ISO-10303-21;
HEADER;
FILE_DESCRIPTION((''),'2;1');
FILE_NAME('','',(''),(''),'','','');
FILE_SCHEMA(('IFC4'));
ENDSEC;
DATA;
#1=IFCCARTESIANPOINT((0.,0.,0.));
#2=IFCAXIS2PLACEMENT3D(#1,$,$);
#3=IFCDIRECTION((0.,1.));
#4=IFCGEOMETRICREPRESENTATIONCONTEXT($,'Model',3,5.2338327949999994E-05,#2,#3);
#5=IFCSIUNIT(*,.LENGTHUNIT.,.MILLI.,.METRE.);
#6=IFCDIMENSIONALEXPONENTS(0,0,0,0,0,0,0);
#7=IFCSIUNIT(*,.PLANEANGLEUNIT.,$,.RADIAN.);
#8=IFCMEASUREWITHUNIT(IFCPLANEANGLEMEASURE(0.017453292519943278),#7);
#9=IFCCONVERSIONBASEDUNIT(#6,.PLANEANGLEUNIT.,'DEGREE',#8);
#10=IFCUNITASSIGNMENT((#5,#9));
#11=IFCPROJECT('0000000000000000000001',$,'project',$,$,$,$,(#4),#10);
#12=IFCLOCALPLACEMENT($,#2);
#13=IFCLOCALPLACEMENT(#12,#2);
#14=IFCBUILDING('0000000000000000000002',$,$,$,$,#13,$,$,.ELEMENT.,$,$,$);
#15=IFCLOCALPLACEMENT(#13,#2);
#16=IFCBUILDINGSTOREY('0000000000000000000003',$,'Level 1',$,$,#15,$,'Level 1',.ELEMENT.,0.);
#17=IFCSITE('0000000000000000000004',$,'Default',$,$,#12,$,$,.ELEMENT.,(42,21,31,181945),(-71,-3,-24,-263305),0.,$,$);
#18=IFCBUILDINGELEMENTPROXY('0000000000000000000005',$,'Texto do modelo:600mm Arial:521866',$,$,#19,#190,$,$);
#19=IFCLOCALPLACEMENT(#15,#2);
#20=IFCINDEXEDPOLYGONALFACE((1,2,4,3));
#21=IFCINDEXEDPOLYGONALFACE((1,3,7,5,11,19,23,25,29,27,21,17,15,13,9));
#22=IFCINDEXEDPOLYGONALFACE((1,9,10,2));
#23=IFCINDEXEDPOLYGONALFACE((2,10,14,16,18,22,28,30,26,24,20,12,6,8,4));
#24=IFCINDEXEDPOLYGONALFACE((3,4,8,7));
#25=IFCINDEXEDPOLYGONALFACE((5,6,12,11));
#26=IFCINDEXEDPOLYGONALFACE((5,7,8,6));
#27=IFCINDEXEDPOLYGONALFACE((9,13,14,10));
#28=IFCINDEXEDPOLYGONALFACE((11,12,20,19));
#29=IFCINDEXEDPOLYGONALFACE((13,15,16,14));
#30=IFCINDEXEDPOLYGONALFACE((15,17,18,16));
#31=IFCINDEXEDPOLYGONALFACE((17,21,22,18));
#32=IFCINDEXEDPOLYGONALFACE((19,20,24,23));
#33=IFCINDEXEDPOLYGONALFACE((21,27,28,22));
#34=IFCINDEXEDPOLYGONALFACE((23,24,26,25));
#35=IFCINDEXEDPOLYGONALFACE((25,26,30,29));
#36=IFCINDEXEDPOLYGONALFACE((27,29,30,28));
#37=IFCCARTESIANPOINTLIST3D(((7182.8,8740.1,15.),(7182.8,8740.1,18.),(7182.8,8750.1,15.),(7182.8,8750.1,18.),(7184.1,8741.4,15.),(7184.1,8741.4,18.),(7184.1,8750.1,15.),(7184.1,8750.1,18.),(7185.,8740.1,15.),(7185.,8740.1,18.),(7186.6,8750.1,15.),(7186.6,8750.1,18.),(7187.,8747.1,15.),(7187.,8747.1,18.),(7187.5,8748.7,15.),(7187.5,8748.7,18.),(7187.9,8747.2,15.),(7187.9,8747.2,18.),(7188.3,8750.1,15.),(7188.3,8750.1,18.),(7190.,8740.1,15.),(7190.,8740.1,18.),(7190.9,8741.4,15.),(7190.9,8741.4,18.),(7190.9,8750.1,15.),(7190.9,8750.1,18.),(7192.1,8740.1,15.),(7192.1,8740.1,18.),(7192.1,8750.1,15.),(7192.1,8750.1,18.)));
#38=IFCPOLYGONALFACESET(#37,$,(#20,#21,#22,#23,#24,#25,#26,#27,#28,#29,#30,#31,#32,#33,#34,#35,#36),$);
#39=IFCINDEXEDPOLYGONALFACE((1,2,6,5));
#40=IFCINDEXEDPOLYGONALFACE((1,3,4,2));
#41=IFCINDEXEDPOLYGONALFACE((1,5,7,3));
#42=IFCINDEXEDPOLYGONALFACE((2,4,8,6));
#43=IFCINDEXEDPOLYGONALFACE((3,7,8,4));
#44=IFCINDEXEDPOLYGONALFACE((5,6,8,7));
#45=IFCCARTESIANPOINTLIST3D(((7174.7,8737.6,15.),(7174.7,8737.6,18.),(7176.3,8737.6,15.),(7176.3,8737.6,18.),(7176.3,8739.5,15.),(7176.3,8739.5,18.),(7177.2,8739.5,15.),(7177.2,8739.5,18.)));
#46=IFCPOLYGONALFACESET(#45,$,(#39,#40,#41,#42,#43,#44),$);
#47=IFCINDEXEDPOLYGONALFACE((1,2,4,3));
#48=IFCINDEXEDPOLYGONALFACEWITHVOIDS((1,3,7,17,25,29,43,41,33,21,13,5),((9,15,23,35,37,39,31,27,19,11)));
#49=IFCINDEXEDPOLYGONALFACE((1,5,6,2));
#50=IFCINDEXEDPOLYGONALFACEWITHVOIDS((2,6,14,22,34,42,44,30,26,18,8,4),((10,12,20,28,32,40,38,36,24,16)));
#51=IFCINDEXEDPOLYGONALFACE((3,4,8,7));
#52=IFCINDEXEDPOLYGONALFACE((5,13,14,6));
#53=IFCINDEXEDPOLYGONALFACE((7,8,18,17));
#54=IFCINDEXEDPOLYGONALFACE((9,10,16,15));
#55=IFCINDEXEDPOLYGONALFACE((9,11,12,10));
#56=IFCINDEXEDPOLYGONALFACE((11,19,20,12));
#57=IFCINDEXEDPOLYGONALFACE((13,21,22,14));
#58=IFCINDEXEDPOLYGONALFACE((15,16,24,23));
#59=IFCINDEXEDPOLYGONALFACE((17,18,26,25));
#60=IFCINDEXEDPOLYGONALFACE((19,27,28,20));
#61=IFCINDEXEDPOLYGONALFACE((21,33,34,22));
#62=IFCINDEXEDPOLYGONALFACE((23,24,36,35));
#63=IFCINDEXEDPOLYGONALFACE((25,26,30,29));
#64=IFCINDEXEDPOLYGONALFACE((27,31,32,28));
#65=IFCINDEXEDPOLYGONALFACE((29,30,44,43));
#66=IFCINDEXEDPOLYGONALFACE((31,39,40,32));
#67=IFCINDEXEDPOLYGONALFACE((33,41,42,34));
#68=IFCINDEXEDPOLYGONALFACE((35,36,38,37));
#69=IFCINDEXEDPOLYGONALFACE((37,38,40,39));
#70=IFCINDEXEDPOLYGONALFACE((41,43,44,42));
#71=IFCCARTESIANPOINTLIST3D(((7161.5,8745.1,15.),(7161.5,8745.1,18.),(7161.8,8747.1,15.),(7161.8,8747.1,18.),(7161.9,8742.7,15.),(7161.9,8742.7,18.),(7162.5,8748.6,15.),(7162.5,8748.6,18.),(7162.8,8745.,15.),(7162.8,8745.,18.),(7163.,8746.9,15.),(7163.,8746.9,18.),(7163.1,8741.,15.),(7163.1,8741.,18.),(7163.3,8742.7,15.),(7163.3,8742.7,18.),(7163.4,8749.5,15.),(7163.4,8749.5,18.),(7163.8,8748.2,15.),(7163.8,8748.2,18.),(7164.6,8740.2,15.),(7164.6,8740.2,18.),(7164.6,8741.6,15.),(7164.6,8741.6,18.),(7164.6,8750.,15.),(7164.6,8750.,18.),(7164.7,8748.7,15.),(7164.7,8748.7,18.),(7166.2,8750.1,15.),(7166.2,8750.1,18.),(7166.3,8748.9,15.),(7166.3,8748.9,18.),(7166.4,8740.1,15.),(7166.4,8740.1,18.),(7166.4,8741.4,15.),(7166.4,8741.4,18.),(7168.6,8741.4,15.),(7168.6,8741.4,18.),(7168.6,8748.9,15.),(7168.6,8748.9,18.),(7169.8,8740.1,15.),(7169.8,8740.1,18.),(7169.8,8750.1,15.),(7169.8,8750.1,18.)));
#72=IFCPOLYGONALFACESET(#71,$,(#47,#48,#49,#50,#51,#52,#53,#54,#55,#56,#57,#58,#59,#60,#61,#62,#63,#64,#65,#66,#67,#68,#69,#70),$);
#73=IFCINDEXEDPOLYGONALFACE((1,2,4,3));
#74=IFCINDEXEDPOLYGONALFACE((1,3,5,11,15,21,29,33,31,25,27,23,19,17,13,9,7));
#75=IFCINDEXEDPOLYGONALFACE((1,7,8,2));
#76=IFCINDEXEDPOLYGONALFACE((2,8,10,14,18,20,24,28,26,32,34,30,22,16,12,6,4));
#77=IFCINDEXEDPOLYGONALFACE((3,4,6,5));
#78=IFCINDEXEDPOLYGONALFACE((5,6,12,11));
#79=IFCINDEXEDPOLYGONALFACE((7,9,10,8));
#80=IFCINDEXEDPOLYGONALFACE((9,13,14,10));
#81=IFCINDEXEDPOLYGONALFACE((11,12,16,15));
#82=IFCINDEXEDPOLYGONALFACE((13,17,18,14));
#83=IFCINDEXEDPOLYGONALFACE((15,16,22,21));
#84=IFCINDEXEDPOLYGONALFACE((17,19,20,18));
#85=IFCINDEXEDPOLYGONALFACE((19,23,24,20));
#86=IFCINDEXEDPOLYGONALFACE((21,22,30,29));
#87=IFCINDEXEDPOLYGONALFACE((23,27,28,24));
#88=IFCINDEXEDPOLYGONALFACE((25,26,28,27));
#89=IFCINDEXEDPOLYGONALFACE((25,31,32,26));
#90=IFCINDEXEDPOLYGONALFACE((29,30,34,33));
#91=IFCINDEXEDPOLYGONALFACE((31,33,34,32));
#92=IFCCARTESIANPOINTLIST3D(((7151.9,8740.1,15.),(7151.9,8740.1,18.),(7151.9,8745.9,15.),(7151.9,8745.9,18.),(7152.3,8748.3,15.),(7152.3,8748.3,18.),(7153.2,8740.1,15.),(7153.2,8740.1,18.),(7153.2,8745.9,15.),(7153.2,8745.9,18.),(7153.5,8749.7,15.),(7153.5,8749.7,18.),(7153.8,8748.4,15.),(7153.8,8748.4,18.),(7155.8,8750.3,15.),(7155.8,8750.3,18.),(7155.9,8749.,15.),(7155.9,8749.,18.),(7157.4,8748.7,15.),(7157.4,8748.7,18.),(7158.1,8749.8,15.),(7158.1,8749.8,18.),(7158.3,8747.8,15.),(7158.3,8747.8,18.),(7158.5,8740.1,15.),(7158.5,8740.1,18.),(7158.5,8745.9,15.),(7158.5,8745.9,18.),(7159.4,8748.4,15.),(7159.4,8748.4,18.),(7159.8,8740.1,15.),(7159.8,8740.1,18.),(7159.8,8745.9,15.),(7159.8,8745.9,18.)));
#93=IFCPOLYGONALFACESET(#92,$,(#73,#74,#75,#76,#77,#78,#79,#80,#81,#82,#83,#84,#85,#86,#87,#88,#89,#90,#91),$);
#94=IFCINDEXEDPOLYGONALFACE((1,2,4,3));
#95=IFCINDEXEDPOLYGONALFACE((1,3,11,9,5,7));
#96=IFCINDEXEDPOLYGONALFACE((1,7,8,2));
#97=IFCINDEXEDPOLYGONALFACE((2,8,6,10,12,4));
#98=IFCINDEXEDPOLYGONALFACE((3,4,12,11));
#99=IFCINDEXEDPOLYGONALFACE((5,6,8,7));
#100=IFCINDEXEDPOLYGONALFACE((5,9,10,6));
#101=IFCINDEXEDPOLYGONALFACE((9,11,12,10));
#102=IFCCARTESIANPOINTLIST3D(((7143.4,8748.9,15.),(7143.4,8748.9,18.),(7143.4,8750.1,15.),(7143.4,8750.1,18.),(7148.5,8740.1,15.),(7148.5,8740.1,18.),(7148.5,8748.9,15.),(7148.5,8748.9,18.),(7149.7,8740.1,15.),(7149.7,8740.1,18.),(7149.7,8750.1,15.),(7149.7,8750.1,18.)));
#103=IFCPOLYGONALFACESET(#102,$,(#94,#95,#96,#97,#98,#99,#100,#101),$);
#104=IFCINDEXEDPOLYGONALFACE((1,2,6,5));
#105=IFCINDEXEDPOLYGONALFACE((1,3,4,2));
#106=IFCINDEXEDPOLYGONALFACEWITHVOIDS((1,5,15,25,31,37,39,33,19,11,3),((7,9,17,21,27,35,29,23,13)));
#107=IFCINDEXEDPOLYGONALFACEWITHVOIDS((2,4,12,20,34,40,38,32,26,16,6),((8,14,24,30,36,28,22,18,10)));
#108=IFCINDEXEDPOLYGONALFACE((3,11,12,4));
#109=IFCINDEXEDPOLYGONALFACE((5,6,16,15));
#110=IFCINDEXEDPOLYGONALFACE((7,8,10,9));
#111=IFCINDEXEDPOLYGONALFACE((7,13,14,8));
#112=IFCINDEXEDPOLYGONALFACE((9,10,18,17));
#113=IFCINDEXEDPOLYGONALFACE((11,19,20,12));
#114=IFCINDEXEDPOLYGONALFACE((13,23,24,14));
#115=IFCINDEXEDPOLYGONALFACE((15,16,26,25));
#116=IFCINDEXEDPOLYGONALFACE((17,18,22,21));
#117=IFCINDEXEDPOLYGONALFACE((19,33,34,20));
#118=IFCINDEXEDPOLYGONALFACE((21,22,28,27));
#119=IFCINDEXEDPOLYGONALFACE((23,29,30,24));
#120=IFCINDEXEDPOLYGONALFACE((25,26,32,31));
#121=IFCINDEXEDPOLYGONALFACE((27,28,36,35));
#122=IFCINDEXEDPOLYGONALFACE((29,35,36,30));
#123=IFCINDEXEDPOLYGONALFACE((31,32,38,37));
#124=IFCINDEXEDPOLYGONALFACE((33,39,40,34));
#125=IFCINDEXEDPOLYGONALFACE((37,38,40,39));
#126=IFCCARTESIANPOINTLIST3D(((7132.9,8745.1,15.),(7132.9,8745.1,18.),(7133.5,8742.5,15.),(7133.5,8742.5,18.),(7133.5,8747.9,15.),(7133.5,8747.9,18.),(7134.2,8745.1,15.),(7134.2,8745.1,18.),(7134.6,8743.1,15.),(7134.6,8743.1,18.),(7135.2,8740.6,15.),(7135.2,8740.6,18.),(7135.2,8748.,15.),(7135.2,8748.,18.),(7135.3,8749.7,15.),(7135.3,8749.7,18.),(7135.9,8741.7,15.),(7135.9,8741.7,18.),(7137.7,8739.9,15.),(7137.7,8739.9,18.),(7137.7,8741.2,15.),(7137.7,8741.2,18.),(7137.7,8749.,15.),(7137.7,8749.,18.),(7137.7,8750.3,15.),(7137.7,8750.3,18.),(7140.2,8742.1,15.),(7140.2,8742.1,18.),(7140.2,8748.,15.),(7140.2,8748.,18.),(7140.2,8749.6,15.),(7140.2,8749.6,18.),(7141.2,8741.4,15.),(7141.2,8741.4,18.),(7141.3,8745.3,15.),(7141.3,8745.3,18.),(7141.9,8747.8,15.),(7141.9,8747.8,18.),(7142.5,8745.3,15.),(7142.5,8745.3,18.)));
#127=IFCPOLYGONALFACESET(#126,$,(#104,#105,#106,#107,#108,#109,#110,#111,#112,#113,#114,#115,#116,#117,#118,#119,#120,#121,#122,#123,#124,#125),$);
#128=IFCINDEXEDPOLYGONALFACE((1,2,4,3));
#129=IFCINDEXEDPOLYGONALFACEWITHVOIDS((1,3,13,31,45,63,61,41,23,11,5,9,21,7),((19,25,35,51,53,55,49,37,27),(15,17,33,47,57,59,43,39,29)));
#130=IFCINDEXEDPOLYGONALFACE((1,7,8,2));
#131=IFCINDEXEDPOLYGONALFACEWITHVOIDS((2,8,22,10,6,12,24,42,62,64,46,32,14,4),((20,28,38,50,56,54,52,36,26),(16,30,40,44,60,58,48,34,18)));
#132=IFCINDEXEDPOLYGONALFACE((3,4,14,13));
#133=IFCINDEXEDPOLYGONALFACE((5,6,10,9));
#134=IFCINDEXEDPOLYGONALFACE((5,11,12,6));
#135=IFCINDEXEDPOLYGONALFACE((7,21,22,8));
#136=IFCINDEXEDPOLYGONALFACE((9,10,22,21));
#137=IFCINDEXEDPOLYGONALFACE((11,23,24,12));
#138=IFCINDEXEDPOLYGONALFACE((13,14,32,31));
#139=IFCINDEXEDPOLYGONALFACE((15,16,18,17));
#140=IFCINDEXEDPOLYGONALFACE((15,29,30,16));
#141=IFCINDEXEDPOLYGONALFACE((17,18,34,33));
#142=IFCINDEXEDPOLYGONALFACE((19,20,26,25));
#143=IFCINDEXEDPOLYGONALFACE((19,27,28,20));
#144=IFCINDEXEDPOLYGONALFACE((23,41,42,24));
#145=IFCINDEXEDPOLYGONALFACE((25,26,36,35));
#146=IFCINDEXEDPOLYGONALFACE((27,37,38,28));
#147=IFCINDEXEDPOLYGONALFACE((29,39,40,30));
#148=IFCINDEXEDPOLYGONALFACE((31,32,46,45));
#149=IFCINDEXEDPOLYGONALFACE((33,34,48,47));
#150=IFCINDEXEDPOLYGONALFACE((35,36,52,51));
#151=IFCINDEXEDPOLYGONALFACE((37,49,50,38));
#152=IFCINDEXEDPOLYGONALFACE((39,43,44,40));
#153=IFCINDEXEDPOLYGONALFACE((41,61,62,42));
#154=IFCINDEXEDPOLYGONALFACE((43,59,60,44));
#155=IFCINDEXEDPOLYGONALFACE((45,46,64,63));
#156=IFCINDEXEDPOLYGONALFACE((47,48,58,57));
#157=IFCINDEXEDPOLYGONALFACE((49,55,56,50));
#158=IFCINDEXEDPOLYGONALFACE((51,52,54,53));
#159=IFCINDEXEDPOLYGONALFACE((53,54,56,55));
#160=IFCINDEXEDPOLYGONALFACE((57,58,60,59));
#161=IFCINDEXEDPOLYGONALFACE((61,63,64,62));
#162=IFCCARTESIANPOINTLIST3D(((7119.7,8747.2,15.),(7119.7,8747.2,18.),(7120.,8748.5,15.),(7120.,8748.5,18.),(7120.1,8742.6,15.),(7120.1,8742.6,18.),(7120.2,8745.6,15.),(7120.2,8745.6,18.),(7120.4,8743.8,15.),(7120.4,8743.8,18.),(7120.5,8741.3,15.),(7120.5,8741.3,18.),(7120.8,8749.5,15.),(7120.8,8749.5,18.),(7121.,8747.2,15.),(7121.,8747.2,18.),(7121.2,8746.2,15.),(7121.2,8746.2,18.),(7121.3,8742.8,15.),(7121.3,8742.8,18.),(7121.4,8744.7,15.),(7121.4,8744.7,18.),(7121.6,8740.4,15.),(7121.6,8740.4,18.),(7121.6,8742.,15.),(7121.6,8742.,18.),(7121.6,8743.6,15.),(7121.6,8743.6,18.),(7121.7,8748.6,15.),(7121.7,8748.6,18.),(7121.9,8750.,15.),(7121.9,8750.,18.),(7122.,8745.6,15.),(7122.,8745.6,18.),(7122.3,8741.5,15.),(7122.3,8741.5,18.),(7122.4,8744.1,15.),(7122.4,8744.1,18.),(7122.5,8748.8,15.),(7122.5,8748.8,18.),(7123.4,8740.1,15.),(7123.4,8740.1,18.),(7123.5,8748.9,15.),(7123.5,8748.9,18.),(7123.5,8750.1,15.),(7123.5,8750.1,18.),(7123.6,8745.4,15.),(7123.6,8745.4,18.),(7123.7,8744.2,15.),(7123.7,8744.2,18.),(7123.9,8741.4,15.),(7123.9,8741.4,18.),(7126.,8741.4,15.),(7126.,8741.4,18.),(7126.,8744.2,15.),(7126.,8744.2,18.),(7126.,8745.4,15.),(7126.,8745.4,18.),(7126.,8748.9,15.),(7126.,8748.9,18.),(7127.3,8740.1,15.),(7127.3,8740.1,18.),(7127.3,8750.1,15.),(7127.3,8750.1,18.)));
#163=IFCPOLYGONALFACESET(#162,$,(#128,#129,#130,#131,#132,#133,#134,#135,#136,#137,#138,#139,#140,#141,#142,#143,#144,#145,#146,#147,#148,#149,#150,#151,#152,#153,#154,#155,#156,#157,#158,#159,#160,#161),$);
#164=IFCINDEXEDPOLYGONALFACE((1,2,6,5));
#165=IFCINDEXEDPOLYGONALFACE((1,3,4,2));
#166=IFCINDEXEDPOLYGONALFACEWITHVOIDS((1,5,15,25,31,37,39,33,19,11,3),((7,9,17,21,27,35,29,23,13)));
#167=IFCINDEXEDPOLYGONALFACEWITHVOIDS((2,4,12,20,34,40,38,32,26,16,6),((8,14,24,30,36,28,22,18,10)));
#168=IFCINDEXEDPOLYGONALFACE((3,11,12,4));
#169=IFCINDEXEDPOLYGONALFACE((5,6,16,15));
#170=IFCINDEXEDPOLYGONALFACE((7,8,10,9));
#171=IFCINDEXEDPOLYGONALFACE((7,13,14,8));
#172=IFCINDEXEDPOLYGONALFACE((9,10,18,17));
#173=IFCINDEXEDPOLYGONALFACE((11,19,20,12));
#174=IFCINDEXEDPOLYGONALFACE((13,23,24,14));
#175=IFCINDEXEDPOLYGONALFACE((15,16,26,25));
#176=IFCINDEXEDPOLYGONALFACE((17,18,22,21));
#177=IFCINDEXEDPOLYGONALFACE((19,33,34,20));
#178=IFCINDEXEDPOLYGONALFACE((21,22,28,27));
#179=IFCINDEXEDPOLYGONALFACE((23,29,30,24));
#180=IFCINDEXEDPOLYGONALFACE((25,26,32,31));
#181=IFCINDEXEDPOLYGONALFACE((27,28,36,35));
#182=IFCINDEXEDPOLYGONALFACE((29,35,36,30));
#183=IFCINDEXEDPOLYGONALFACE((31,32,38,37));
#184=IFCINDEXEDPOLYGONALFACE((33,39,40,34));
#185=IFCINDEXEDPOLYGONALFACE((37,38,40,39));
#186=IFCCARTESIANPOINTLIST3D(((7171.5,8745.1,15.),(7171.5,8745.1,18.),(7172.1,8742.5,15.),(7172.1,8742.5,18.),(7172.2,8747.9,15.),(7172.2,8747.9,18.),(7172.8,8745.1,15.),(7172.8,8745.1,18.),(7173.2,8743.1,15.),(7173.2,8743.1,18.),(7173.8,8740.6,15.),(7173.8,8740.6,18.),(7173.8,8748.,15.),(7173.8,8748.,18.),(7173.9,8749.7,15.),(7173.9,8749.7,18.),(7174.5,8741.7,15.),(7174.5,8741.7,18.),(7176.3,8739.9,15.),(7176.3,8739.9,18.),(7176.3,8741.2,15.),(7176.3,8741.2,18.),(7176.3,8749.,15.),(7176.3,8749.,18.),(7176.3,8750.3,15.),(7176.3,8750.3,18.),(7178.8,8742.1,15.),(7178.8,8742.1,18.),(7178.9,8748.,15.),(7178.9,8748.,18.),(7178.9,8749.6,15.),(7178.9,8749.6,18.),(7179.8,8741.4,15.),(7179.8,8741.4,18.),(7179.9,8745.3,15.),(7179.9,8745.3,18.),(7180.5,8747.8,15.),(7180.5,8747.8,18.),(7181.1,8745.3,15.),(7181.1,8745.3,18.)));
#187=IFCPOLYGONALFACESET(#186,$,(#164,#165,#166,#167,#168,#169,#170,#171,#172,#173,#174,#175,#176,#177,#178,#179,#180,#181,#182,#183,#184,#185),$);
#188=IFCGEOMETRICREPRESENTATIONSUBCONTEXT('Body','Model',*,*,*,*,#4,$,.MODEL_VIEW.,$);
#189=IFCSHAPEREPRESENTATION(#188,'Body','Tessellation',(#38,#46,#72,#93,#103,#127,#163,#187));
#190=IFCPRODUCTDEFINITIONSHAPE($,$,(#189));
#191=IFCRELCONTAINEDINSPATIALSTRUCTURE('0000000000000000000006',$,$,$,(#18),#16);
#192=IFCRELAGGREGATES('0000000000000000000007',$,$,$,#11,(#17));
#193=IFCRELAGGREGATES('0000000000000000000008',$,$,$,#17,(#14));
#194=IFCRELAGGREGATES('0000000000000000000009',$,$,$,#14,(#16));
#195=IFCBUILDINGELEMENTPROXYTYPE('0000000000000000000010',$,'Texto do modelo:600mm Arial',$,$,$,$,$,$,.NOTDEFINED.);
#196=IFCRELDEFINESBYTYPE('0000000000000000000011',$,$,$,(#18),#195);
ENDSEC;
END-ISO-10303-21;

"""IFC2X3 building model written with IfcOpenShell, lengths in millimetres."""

from ifc_helpers import new_model, entity, si_unit, converted_unit, direction, frame, origin, place, context, subcontext, project, spatial, polyline, outline, extrude, type_object, element, save


model = new_model("IFC2X3")

# Units and contexts
model_context = context("Model", 3, precision=5.2338327949999994e-05, world=origin(), true_north=direction((0.0, 1.0)))
body_context = subcontext(model_context, "Body", "Model", "MODEL_VIEW")
ifc_project = project(units=[si_unit("LENGTHUNIT", "METRE", prefix="MILLI"), converted_unit("PLANEANGLEUNIT", "DEGREE", entity("IfcPlaneAngleMeasure", 0.017453292519943278), si_unit("PLANEANGLEUNIT", "RADIAN"), dimensions=[0, 0, 0, 0, 0, 0, 0])], contexts=[model_context])

# Site, building, storey
site_placement = place(None, origin())
site = spatial("IfcSite", under=ifc_project, at=site_placement, Name="Default", CompositionType="ELEMENT", RefLatitude=(42, 21, 31, 181945), RefLongitude=(-71, -3, -24, -263305), RefElevation=0.0)
building_placement = place(site_placement, origin())
building = spatial("IfcBuilding", under=site, at=building_placement, CompositionType="ELEMENT")
storey_placement = place(building_placement, origin())
storey = spatial("IfcBuildingStorey", under=building, at=storey_placement, Name="Level 1", LongName="Level 1", CompositionType="ELEMENT", Elevation=0.0)

# Building element proxy
building_element_proxy_type_1 = type_object("IfcBuildingElementProxyType", Name="Texto do modelo:600mm Arial", PredefinedType="NOTDEFINED")
proxy_1_placement = place(storey_placement, origin())
element("IfcBuildingElementProxy", 1, at=proxy_1_placement, inside=storey, type_object=building_element_proxy_type_1, Name="Texto do modelo:600mm Arial:521866", context=body_context, shape_type="SweptSolid", body=[
    extrude(outline(polyline([(-4.6, -4.4), (-3.4, -4.4), (-3.4, 4.4), (-0.9, -4.4), (0.8, -4.4), (3.4, 4.4), (3.4, -4.4), (4.6, -4.4), (4.6, 5.7), (2.5, 5.7), (0.4, -1.3), (0.0, -2.9), (-0.4, -1.4), (-2.5, 5.7), (-4.6, 5.7), (-4.6, -4.4)])), frame((7187.5, 8745.8, 15.0), z_axis=(0.0, 0.0, 1.0), x_axis=(-1.0, 0.0, 0.0)), (0.0, 0.0, 1.0), 3.0),
    extrude(outline(polyline([(-1.1, -0.9), (-0.2, -0.9), (1.4, 0.9), (-0.2, 0.9), (-1.1, -0.9)])), frame((7176.1, 8738.5, 15.0), z_axis=(0.0, 0.0, 1.0), x_axis=(-1.0, 0.0, 0.0)), (0.0, 0.0, 1.0), 3.0),
    extrude(outline(polyline([(-5.2, -4.8), (-1.6, -4.8), (0.0, -4.6), (1.2, -4.1), (2.2, -3.2), (2.8, -1.7), (3.1, 0.3), (2.7, 2.7), (1.5, 4.4), (0.1, 5.1), (-1.7, 5.3), (-5.2, 5.3), (-5.2, -4.8)]), holes=[polyline([(-3.9, -3.5), (-3.9, 4.0), (-1.8, 4.0), (0.0, 3.8), (1.3, 2.7), (1.9, 0.3), (1.6, -1.6), (0.8, -2.8), (-0.1, -3.3), (-1.7, -3.5), (-3.9, -3.5)])]), frame((7164.6, 8745.4, 15.0), z_axis=(0.0, 0.0, 1.0), x_axis=(-1.0, 0.0, 0.0)), (0.0, 0.0, 1.0), 3.0),
    extrude(outline(polyline([(-6.0, -2.8), (-6.0, -4.0), (-0.2, -4.0), (2.2, -3.7), (3.6, -2.5), (4.2, -0.1), (3.7, 2.2), (2.3, 3.4), (-0.2, 3.8), (-6.0, 3.8), (-6.0, 2.6), (-0.3, 2.6), (1.6, 2.3), (2.6, 1.5), (2.9, 0.0), (2.2, -2.1), (-0.3, -2.8), (-6.0, -2.8)])), frame((7156.0, 8746.1, 15.0), z_axis=(0.0, 0.0, -1.0), x_axis=(0.0, 1.0, 0.0)), (0.0, 0.0, -1.0), 3.0),
    extrude(outline(polyline([(-2.5, -3.8), (3.8, -3.8), (3.8, -2.5), (-1.3, -2.5), (-1.3, 6.3), (-2.5, 6.3), (-2.5, -3.8)])), frame((7147.2, 8746.4, 15.0), z_axis=(0.0, 0.0, 1.0), x_axis=(-1.0, 0.0, 0.0)), (0.0, 0.0, 1.0), 3.0),
    extrude(outline(polyline([(-1.3, -4.9), (1.2, -4.9), (3.4, -3.7), (4.7, -1.4), (4.6, 1.1), (3.2, 3.2), (0.7, 4.5), (-2.0, 4.5), (-4.2, 3.2), (-5.4, 1.0), (-4.8, -2.7), (-1.3, -4.9)]), holes=[polyline([(-1.0, -3.7), (-3.9, -2.0), (-4.2, 0.7), (-3.3, 2.4), (-1.7, 3.3), (0.4, 3.2), (3.0, 1.6), (3.4, -1.1), (1.9, -3.3), (-1.0, -3.7)])]), frame((7137.4, 8745.5, 15.0), z_axis=(0.0, 0.0, 1.0), x_axis=(-0.223707, 0.974656, 0.0)), (0.0, 0.0, 1.0), 3.0),
    extrude(outline(polyline([(-5.3, -4.9), (-1.5, -4.9), (0.1, -4.7), (1.2, -4.2), (2.0, -3.2), (2.3, -1.9), (1.8, -0.3), (0.6, 0.6), (1.6, 1.5), (1.9, 2.7), (1.5, 4.0), (0.4, 4.9), (-1.4, 5.2), (-5.3, 5.2), (-5.3, -4.9)]), holes=[polyline([(-4.0, 1.1), (-4.0, 3.9), (-1.9, 3.9), (-0.3, 3.8), (0.4, 3.3), (0.7, 2.5), (0.4, 1.7), (-0.4, 1.2), (-1.7, 1.1), (-4.0, 1.1)]), polyline([(-4.0, -3.6), (-4.0, -0.2), (-1.6, -0.2), (0.0, -0.3), (0.8, -0.9), (1.0, -1.9), (0.3, -3.3), (-0.5, -3.6), (-1.4, -3.6), (-4.0, -3.6)])]), frame((7122.0, 8745.3, 15.0), z_axis=(0.0, 0.0, 1.0), x_axis=(-1.0, 0.0, 0.0)), (0.0, 0.0, 1.0), 3.0),
    extrude(outline(polyline([(-1.3, -4.9), (1.2, -4.9), (3.4, -3.7), (4.7, -1.4), (4.6, 1.1), (3.2, 3.2), (0.7, 4.5), (-2.0, 4.5), (-4.2, 3.2), (-5.4, 1.0), (-4.8, -2.7), (-1.3, -4.9)]), holes=[polyline([(-1.0, -3.7), (-3.9, -2.0), (-4.2, 0.7), (-3.3, 2.4), (-1.7, 3.3), (0.4, 3.2), (3.0, 1.6), (3.4, -1.1), (1.9, -3.3), (-1.0, -3.7)])]), frame((7176.0, 8745.5, 15.0), z_axis=(0.0, 0.0, 1.0), x_axis=(-0.223707, 0.974656, 0.0)), (0.0, 0.0, 1.0), 3.0),
])

save(model, "model.ifc")
